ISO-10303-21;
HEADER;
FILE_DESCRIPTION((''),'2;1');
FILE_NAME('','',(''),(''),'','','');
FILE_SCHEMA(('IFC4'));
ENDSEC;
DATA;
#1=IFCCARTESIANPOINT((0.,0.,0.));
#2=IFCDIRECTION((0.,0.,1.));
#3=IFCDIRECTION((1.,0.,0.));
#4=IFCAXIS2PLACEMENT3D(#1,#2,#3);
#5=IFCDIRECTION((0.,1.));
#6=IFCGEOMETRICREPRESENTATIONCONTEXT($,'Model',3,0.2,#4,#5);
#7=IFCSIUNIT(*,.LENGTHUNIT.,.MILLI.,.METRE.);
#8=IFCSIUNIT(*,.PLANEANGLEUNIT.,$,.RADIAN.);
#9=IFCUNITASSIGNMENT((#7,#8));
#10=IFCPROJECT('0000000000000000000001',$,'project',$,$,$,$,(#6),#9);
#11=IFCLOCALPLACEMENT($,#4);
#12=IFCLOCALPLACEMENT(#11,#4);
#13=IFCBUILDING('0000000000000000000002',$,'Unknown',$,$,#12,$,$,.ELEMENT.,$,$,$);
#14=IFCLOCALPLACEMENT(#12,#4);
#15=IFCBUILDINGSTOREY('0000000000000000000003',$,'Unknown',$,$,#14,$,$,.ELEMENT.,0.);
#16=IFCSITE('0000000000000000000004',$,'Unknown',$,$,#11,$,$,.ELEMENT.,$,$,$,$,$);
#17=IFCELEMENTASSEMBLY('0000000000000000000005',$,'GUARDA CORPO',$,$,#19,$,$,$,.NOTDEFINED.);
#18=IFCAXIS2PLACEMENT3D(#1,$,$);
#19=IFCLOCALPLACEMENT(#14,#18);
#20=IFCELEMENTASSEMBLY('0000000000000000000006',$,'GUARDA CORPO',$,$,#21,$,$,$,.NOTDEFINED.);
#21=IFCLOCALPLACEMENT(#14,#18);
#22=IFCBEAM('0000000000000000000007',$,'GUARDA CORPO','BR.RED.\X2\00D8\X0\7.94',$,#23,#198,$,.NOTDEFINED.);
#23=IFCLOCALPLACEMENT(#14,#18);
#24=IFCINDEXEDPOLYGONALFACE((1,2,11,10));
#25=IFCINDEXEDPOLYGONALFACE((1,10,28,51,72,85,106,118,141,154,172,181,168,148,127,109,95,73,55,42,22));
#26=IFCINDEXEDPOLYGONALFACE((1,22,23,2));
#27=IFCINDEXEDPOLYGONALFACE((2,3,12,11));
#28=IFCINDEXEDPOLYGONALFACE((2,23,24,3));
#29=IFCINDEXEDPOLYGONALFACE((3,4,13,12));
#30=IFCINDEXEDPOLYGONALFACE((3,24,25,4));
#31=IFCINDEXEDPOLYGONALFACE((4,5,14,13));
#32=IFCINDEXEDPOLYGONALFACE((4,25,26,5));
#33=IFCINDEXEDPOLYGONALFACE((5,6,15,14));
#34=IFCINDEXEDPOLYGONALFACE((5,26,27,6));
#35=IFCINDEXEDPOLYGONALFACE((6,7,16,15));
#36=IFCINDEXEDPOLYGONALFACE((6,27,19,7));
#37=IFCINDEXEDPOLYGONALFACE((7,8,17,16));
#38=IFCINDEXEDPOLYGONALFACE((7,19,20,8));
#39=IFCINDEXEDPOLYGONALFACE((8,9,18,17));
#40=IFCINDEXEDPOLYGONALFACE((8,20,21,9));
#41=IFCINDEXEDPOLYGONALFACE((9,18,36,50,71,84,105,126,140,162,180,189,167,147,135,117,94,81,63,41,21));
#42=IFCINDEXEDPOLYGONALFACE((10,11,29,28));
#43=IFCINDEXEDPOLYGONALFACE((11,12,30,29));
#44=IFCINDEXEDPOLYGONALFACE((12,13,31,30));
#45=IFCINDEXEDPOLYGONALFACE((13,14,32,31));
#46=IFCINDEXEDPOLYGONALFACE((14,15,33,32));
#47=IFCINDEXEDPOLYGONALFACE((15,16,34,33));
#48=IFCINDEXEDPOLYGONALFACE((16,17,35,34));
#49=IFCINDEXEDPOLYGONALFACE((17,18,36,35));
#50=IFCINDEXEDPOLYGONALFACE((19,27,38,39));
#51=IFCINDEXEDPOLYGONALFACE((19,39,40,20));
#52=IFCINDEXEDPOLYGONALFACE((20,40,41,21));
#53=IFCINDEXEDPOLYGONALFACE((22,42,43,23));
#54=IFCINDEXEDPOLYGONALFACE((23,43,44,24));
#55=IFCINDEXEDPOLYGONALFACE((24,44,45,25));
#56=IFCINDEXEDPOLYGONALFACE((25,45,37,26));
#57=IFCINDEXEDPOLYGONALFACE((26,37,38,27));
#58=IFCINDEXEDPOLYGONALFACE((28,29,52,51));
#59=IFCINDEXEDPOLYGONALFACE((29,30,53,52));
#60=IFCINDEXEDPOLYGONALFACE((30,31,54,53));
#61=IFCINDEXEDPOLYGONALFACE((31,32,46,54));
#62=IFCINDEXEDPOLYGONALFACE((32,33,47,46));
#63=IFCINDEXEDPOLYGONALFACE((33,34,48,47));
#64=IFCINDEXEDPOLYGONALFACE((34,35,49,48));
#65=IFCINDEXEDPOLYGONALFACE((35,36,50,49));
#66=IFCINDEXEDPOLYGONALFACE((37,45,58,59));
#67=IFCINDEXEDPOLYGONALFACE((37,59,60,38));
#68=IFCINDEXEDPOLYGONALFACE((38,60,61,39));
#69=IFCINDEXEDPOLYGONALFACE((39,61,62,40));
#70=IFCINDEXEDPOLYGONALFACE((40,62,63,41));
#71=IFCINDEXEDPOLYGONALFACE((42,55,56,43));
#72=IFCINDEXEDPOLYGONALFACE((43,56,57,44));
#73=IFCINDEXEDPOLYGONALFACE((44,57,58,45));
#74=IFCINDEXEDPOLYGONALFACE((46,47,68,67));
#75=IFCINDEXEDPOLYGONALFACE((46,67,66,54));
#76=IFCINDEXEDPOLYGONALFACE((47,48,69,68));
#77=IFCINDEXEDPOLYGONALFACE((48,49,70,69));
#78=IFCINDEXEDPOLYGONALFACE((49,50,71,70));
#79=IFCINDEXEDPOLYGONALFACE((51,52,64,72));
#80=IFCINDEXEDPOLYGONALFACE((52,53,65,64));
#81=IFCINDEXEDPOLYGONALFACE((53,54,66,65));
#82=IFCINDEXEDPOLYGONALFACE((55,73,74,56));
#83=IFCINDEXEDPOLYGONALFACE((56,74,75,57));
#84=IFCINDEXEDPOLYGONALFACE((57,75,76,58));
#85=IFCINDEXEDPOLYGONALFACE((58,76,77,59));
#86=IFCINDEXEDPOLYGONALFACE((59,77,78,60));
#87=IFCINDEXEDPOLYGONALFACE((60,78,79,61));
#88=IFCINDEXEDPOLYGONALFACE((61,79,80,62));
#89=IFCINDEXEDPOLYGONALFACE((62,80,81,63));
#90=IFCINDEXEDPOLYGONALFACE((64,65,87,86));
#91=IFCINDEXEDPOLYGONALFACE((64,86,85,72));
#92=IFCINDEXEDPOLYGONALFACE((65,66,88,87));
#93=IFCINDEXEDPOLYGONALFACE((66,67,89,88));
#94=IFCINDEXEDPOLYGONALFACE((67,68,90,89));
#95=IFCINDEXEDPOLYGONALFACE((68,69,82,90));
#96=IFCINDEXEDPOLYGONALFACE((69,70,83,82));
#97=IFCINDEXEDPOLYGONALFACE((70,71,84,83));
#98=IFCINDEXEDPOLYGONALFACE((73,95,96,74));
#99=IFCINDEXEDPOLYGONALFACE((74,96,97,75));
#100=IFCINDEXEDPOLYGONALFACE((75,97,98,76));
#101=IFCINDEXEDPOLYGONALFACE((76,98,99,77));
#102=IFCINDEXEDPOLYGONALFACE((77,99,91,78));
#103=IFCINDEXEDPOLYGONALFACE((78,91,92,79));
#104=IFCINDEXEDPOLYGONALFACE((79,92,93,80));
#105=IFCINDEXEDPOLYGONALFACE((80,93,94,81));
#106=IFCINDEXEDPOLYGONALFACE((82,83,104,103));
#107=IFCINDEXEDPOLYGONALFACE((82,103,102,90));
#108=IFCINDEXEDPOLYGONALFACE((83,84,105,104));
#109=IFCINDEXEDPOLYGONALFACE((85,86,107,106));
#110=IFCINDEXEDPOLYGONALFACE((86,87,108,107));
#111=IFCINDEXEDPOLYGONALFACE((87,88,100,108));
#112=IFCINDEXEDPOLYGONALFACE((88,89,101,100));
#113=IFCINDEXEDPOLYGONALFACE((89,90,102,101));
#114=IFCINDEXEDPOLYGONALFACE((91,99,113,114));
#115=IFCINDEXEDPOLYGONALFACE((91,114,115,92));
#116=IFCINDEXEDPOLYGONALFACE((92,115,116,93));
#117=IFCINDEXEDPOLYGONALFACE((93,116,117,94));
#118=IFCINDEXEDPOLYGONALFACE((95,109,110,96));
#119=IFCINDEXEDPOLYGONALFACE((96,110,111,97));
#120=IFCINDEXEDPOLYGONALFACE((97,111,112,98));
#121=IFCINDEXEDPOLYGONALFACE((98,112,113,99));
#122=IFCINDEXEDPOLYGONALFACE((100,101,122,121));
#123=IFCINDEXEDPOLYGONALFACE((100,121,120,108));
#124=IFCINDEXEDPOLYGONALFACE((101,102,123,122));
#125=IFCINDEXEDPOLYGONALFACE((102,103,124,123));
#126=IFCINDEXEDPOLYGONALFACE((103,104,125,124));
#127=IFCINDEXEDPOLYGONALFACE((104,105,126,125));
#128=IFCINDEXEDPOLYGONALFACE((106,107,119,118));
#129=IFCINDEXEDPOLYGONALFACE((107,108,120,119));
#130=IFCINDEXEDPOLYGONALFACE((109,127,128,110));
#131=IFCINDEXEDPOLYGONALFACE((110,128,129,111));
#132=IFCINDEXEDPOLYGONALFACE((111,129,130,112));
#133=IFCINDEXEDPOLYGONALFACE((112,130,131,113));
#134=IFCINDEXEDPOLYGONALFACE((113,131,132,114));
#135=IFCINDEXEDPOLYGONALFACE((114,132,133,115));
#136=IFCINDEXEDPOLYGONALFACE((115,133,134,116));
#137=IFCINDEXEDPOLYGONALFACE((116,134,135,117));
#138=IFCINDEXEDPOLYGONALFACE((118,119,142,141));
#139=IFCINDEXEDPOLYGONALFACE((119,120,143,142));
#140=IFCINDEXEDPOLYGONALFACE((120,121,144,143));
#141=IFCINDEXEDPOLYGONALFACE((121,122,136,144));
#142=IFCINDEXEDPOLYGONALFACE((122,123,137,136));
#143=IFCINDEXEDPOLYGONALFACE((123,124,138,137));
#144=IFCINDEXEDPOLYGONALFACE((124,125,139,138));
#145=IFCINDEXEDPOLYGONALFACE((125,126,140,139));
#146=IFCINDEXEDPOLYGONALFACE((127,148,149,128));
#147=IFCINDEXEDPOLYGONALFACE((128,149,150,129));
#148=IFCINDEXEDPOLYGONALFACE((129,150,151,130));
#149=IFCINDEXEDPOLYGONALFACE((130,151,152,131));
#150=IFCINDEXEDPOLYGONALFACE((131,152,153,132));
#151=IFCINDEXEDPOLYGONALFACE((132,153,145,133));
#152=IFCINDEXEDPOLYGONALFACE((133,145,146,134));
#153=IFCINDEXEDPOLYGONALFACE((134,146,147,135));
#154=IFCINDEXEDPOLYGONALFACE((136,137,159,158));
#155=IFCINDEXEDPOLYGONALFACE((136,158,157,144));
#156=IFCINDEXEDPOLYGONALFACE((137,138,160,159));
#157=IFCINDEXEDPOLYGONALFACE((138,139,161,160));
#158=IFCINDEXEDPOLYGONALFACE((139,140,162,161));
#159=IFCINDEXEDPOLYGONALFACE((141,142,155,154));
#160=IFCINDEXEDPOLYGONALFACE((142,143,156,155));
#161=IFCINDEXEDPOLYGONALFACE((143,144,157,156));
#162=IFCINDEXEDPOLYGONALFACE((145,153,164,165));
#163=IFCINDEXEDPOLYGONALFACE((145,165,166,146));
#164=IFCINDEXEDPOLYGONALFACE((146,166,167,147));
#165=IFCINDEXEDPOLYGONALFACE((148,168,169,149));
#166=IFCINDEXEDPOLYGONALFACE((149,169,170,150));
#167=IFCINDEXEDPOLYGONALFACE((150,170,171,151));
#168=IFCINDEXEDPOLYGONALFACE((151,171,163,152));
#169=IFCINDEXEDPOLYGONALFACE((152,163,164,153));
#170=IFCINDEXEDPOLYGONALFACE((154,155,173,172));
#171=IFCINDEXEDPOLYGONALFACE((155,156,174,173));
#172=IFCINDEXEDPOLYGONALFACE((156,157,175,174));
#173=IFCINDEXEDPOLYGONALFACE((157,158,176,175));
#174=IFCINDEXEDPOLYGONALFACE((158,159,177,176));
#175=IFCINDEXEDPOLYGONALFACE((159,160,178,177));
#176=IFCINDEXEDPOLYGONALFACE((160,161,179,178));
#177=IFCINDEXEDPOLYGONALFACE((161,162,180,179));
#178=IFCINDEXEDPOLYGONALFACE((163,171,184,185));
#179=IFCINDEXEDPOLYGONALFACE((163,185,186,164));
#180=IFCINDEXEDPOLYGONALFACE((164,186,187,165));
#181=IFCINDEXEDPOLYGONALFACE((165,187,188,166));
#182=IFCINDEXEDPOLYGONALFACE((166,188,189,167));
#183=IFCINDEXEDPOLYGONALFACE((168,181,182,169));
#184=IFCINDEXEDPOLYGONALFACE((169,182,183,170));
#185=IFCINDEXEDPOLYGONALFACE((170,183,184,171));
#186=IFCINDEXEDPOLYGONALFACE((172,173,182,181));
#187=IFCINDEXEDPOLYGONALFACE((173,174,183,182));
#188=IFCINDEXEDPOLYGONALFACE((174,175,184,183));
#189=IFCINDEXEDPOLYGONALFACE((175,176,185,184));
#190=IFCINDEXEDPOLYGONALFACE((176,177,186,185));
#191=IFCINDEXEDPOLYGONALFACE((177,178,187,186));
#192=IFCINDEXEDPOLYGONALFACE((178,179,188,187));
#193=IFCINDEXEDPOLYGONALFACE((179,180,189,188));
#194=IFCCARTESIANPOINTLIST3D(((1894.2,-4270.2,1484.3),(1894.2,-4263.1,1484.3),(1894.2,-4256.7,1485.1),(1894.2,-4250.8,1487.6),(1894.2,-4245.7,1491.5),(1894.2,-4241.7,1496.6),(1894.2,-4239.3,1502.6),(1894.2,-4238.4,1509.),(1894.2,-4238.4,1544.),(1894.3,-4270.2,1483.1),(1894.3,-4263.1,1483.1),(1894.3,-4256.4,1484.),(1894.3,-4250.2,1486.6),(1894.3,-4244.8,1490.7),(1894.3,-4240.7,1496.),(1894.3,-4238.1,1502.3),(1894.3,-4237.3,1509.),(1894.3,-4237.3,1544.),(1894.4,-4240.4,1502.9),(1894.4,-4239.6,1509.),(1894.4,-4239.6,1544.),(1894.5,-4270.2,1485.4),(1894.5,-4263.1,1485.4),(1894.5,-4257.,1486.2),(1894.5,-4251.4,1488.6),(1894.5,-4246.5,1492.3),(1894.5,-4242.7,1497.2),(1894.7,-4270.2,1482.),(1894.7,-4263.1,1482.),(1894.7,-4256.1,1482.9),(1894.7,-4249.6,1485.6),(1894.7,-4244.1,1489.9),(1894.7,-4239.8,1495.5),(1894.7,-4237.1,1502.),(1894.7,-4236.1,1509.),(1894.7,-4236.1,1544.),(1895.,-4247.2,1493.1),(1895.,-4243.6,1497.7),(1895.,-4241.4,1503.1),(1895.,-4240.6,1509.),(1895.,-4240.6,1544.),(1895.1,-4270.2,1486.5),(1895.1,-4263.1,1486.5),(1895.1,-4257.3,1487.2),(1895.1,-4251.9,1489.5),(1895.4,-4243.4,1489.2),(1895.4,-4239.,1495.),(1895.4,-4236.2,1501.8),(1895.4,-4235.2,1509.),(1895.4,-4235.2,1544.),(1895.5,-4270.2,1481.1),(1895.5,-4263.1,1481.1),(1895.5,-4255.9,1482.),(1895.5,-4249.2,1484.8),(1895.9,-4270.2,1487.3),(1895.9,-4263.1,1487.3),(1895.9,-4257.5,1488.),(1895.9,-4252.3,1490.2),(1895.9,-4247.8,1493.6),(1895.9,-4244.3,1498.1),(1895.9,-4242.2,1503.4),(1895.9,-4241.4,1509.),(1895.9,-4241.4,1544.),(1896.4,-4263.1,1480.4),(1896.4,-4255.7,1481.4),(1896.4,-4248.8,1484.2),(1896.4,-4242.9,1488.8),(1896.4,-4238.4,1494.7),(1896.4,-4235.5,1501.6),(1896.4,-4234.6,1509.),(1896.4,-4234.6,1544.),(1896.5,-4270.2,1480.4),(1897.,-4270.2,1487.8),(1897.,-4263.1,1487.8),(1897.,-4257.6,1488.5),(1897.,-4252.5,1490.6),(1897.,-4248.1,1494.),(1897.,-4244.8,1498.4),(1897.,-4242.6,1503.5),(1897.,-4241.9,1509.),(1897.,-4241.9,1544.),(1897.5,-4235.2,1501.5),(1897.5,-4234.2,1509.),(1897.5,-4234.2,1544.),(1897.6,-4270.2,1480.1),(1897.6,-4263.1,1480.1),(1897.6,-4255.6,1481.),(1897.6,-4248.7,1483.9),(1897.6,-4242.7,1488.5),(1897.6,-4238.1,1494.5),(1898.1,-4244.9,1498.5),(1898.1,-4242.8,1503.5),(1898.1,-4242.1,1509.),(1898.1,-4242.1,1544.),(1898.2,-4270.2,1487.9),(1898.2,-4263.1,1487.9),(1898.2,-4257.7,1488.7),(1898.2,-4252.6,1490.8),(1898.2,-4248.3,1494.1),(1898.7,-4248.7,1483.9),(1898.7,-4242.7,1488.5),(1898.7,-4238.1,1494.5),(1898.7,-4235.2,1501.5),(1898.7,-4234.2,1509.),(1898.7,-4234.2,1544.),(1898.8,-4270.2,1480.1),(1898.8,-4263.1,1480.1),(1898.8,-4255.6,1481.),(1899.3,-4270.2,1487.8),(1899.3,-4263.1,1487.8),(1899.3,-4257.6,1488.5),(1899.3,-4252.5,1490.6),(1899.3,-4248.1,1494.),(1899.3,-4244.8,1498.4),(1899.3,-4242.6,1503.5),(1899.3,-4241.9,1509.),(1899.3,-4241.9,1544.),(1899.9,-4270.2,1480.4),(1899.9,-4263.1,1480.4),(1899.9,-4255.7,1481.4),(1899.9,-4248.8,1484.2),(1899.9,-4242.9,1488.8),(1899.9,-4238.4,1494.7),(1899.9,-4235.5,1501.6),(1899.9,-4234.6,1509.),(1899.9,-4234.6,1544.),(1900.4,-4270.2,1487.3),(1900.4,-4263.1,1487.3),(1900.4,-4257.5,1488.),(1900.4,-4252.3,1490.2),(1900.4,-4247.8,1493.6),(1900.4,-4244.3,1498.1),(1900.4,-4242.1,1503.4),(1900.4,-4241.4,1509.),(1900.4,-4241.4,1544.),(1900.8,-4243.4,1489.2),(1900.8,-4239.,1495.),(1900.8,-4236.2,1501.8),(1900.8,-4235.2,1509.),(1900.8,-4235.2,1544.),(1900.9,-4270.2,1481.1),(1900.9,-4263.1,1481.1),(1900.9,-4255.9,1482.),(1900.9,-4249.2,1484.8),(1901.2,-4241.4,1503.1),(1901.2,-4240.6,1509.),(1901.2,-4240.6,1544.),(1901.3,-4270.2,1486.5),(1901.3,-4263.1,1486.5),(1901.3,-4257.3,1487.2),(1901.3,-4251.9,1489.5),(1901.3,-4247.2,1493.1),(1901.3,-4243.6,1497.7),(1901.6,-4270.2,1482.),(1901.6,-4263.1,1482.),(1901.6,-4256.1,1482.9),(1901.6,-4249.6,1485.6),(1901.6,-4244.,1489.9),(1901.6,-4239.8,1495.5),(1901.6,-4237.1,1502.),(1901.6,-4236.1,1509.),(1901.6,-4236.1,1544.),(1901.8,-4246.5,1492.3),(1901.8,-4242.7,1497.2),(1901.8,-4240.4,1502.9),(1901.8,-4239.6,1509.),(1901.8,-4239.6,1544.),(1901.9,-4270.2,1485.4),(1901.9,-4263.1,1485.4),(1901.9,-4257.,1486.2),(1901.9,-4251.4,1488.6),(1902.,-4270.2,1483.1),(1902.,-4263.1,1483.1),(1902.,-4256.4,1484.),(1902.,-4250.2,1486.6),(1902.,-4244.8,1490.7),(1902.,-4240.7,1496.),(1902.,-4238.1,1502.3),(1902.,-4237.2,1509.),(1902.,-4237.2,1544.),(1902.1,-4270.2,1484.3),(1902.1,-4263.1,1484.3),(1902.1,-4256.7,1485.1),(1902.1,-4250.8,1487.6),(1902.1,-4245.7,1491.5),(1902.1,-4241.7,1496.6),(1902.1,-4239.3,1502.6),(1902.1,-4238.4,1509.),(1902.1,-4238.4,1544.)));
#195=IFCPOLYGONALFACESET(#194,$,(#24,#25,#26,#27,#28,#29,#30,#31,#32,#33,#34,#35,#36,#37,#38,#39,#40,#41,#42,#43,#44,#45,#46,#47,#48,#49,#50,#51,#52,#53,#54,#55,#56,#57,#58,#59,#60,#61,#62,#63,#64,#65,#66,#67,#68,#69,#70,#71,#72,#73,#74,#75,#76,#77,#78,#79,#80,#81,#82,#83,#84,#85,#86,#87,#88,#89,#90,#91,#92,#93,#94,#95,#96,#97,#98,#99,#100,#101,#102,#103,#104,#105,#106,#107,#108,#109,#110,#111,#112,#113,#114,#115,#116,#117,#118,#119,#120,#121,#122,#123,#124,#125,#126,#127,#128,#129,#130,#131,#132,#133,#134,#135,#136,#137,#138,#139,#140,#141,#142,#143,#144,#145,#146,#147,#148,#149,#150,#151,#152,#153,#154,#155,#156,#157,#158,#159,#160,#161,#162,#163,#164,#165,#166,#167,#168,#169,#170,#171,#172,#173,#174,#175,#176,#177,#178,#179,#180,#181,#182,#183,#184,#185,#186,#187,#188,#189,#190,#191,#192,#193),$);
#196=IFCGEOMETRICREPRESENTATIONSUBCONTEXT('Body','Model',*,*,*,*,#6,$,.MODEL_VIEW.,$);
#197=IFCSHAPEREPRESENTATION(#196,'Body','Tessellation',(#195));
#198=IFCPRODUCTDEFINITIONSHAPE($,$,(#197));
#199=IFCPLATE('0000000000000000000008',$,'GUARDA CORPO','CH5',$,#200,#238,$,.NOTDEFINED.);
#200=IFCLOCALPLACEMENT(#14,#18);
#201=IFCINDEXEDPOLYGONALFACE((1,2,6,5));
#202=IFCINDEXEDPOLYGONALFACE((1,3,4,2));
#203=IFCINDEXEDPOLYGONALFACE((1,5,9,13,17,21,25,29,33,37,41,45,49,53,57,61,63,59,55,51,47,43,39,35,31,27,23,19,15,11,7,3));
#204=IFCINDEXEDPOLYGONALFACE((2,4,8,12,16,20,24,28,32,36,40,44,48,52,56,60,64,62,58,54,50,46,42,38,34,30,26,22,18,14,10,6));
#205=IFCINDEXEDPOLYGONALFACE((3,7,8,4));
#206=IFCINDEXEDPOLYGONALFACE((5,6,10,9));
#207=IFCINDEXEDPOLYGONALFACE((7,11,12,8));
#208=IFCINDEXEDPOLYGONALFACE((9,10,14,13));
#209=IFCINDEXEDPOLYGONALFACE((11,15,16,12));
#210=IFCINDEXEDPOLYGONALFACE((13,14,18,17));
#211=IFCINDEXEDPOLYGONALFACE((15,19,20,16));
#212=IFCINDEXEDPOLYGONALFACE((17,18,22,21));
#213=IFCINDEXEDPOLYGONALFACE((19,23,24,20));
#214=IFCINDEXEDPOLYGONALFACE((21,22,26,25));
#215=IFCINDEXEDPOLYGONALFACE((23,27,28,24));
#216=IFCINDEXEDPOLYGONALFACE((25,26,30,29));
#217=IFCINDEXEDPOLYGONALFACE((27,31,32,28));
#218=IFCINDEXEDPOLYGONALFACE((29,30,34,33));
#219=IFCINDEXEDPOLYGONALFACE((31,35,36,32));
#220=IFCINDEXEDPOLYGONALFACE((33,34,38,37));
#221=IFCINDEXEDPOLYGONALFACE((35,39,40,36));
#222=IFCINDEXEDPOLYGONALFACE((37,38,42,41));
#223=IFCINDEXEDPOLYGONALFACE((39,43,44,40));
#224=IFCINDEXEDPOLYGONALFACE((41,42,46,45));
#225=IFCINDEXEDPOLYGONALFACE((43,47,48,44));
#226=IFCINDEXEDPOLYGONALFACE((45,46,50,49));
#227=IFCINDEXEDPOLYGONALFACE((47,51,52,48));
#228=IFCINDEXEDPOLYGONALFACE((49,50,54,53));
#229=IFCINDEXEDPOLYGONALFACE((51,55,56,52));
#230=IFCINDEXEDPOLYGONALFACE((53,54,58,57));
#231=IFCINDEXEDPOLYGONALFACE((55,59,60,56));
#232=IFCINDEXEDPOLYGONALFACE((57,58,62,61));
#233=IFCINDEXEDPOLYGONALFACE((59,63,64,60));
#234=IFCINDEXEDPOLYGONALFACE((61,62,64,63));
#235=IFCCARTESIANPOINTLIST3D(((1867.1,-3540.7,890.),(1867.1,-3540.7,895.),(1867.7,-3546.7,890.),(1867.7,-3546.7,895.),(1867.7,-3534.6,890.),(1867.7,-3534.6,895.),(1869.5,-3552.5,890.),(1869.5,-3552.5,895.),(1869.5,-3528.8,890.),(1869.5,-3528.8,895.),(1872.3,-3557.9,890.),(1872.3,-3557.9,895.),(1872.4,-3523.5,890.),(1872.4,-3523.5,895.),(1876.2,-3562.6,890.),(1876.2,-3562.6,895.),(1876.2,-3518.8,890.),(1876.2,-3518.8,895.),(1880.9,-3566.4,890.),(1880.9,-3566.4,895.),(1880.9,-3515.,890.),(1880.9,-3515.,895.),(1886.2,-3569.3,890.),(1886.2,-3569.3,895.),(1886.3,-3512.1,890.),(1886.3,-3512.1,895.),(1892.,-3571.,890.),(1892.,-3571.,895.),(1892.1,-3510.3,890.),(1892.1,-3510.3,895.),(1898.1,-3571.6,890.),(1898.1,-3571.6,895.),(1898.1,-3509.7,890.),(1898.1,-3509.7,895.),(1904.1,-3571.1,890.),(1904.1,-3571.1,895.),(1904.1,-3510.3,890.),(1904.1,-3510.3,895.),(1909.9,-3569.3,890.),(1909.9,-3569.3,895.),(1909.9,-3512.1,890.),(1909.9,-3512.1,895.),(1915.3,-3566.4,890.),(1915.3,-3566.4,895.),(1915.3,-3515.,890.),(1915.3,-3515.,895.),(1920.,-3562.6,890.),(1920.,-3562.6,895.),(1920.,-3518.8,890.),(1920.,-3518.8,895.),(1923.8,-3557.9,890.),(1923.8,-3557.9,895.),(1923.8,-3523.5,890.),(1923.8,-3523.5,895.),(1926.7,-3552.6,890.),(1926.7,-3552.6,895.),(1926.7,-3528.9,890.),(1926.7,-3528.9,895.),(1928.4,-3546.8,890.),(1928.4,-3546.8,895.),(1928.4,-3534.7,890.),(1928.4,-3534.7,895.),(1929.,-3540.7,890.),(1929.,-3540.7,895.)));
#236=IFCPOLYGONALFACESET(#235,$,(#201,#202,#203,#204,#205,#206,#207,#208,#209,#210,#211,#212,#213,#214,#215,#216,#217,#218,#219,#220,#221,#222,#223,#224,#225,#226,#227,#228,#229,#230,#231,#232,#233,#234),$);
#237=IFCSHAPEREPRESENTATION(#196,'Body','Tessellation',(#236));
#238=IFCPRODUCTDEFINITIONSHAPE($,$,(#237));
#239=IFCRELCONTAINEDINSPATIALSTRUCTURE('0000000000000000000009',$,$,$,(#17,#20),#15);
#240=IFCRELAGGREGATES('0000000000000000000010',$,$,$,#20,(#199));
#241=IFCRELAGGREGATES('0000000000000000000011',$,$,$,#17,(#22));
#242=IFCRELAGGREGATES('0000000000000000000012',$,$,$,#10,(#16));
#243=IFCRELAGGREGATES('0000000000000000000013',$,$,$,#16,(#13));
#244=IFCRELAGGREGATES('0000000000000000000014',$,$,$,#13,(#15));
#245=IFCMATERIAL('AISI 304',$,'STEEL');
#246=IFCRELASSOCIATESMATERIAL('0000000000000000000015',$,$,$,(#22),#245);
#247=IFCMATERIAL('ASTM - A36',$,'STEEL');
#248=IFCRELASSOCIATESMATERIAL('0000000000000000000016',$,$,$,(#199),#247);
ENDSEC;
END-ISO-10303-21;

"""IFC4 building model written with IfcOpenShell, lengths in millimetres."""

from ifc_helpers import new_model, entity, si_unit, direction, frame, origin_with_axes, place, context, subcontext, project, spatial, line, indexed_curve, outline, extrude, material, element, aggregate, save


model = new_model("IFC4")

# Units and contexts
model_context = context("Model", 3, precision=0.2, world=origin_with_axes(), true_north=direction((0.0, 1.0)))
body_context = subcontext(model_context, "Body", "Model", "MODEL_VIEW")
ifc_project = project(units=[si_unit("LENGTHUNIT", "METRE", prefix="MILLI"), si_unit("PLANEANGLEUNIT", "RADIAN")], contexts=[model_context])

# Site, building, storey
site_placement = place(None, origin_with_axes())
site = spatial("IfcSite", under=ifc_project, at=site_placement, Name="Unknown", CompositionType="ELEMENT")
building_placement = place(site_placement, origin_with_axes())
building = spatial("IfcBuilding", under=site, at=building_placement, Name="Unknown", CompositionType="ELEMENT")
storey_placement = place(building_placement, origin_with_axes())
storey = spatial("IfcBuildingStorey", under=building, at=storey_placement, Name="Unknown", CompositionType="ELEMENT", Elevation=0.0)

# Element assembly
assembly_1_placement = place(storey_placement, frame((833.2, -4289.3, 1615.0), z_axis=(-0.000512, 1.0, -0.000003), x_axis=(0.000003, 0.000003, 1.0)))
assembly_1 = element("IfcElementAssembly", 1, at=assembly_1_placement, inside=storey, Name="GUARDA CORPO", PredefinedType="NOTDEFINED")
ifc_material_1 = material(Name="AISI 304", Category="STEEL")

# Element assembly
assembly_2_placement = place(storey_placement, frame((833.2, -3540.7, 1615.0), z_axis=(-0.000512, -1.0, -0.000003), x_axis=(0.000003, -0.000003, 1.0)))
assembly_2 = element("IfcElementAssembly", 2, at=assembly_2_placement, inside=storey, Name="GUARDA CORPO", PredefinedType="NOTDEFINED")

# Beam
beam_1_placement = place(assembly_1_placement, frame((-71.0, 1065.0, 50.6), z_axis=(-0.000003, 0.000512, -1.0), x_axis=(-1.0, 0.0, 0.000003)))
beam_1 = element("IfcBeam", 3, at=beam_1_placement, material=ifc_material_1, Name="GUARDA CORPO", Description="BR.RED.Ø7.94", PredefinedType="NOTDEFINED", context=body_context, shape_type="SolidModel", body=[
    entity("IfcSweptDiskSolid", entity("IfcIndexedPolyCurve", entity("IfcCartesianPointList3D", [[0.0, 0.0, 0.0], [35.0, 0.0, 0.0], [52.7, 0.0, 7.3], [60.0, 0.0, 25.0], [60.0, 0.0, 32.1]]), [entity("IfcLineIndex", [1, 2]), entity("IfcArcIndex", [2, 3, 4]), entity("IfcLineIndex", [4, 5])]), 4.0),
])

# Plate
ifc_material_2 = material(Name="ASTM - A36", Category="STEEL")
plate_1_placement = place(assembly_2_placement, frame((-722.5, -1095.3, 5.5), z_axis=(-1.0, 0.0, 0.0), x_axis=(0.0, 0.290285, 0.95694)))
plate_1 = element("IfcPlate", 4, at=plate_1_placement, material=ifc_material_2, Name="GUARDA CORPO", Description="CH5", PredefinedType="NOTDEFINED", context=body_context, shape_type="SolidModel", body=[
    extrude(outline(indexed_curve([(0.0, 0.0), (6.1, 0.0), (12.0, 1.2), (17.6, 3.5), (22.7, 6.9), (27.0, 11.2), (30.3, 16.2), (32.7, 21.8), (33.8, 27.8), (33.8, 33.8), (32.7, 39.8), (30.3, 45.4), (27.0, 50.4), (22.7, 54.7), (17.6, 58.1), (12.0, 60.4), (6.1, 61.6), (0.0, 61.6), (-6.0, 60.4), (-11.6, 58.1), (-16.6, 54.7), (-20.9, 50.4), (-24.3, 45.4), (-26.6, 39.8), (-27.8, 33.8), (-27.8, 27.8), (-26.6, 21.8), (-24.3, 16.2), (-20.9, 11.2), (-16.6, 6.9), (-11.6, 3.5), (-6.0, 1.2)], segments=[line(1, 2, 3, 4, 5, 6, 7, 8, 9, 10, 11, 12, 13, 14, 15, 16, 17, 18, 19, 20, 21, 22, 23, 24, 25, 26, 27, 28, 29, 30, 31, 32, 1)])), frame((0.0, 0.0, 2.5), z_axis=(0.0, 0.0, 1.0), x_axis=(1.0, 0.0, 0.0)), (0.0, 0.0, -1.0), 5.0),
])

aggregate(assembly_2, [plate_1])
aggregate(assembly_1, [beam_1])

save(model, "model.ifc")
